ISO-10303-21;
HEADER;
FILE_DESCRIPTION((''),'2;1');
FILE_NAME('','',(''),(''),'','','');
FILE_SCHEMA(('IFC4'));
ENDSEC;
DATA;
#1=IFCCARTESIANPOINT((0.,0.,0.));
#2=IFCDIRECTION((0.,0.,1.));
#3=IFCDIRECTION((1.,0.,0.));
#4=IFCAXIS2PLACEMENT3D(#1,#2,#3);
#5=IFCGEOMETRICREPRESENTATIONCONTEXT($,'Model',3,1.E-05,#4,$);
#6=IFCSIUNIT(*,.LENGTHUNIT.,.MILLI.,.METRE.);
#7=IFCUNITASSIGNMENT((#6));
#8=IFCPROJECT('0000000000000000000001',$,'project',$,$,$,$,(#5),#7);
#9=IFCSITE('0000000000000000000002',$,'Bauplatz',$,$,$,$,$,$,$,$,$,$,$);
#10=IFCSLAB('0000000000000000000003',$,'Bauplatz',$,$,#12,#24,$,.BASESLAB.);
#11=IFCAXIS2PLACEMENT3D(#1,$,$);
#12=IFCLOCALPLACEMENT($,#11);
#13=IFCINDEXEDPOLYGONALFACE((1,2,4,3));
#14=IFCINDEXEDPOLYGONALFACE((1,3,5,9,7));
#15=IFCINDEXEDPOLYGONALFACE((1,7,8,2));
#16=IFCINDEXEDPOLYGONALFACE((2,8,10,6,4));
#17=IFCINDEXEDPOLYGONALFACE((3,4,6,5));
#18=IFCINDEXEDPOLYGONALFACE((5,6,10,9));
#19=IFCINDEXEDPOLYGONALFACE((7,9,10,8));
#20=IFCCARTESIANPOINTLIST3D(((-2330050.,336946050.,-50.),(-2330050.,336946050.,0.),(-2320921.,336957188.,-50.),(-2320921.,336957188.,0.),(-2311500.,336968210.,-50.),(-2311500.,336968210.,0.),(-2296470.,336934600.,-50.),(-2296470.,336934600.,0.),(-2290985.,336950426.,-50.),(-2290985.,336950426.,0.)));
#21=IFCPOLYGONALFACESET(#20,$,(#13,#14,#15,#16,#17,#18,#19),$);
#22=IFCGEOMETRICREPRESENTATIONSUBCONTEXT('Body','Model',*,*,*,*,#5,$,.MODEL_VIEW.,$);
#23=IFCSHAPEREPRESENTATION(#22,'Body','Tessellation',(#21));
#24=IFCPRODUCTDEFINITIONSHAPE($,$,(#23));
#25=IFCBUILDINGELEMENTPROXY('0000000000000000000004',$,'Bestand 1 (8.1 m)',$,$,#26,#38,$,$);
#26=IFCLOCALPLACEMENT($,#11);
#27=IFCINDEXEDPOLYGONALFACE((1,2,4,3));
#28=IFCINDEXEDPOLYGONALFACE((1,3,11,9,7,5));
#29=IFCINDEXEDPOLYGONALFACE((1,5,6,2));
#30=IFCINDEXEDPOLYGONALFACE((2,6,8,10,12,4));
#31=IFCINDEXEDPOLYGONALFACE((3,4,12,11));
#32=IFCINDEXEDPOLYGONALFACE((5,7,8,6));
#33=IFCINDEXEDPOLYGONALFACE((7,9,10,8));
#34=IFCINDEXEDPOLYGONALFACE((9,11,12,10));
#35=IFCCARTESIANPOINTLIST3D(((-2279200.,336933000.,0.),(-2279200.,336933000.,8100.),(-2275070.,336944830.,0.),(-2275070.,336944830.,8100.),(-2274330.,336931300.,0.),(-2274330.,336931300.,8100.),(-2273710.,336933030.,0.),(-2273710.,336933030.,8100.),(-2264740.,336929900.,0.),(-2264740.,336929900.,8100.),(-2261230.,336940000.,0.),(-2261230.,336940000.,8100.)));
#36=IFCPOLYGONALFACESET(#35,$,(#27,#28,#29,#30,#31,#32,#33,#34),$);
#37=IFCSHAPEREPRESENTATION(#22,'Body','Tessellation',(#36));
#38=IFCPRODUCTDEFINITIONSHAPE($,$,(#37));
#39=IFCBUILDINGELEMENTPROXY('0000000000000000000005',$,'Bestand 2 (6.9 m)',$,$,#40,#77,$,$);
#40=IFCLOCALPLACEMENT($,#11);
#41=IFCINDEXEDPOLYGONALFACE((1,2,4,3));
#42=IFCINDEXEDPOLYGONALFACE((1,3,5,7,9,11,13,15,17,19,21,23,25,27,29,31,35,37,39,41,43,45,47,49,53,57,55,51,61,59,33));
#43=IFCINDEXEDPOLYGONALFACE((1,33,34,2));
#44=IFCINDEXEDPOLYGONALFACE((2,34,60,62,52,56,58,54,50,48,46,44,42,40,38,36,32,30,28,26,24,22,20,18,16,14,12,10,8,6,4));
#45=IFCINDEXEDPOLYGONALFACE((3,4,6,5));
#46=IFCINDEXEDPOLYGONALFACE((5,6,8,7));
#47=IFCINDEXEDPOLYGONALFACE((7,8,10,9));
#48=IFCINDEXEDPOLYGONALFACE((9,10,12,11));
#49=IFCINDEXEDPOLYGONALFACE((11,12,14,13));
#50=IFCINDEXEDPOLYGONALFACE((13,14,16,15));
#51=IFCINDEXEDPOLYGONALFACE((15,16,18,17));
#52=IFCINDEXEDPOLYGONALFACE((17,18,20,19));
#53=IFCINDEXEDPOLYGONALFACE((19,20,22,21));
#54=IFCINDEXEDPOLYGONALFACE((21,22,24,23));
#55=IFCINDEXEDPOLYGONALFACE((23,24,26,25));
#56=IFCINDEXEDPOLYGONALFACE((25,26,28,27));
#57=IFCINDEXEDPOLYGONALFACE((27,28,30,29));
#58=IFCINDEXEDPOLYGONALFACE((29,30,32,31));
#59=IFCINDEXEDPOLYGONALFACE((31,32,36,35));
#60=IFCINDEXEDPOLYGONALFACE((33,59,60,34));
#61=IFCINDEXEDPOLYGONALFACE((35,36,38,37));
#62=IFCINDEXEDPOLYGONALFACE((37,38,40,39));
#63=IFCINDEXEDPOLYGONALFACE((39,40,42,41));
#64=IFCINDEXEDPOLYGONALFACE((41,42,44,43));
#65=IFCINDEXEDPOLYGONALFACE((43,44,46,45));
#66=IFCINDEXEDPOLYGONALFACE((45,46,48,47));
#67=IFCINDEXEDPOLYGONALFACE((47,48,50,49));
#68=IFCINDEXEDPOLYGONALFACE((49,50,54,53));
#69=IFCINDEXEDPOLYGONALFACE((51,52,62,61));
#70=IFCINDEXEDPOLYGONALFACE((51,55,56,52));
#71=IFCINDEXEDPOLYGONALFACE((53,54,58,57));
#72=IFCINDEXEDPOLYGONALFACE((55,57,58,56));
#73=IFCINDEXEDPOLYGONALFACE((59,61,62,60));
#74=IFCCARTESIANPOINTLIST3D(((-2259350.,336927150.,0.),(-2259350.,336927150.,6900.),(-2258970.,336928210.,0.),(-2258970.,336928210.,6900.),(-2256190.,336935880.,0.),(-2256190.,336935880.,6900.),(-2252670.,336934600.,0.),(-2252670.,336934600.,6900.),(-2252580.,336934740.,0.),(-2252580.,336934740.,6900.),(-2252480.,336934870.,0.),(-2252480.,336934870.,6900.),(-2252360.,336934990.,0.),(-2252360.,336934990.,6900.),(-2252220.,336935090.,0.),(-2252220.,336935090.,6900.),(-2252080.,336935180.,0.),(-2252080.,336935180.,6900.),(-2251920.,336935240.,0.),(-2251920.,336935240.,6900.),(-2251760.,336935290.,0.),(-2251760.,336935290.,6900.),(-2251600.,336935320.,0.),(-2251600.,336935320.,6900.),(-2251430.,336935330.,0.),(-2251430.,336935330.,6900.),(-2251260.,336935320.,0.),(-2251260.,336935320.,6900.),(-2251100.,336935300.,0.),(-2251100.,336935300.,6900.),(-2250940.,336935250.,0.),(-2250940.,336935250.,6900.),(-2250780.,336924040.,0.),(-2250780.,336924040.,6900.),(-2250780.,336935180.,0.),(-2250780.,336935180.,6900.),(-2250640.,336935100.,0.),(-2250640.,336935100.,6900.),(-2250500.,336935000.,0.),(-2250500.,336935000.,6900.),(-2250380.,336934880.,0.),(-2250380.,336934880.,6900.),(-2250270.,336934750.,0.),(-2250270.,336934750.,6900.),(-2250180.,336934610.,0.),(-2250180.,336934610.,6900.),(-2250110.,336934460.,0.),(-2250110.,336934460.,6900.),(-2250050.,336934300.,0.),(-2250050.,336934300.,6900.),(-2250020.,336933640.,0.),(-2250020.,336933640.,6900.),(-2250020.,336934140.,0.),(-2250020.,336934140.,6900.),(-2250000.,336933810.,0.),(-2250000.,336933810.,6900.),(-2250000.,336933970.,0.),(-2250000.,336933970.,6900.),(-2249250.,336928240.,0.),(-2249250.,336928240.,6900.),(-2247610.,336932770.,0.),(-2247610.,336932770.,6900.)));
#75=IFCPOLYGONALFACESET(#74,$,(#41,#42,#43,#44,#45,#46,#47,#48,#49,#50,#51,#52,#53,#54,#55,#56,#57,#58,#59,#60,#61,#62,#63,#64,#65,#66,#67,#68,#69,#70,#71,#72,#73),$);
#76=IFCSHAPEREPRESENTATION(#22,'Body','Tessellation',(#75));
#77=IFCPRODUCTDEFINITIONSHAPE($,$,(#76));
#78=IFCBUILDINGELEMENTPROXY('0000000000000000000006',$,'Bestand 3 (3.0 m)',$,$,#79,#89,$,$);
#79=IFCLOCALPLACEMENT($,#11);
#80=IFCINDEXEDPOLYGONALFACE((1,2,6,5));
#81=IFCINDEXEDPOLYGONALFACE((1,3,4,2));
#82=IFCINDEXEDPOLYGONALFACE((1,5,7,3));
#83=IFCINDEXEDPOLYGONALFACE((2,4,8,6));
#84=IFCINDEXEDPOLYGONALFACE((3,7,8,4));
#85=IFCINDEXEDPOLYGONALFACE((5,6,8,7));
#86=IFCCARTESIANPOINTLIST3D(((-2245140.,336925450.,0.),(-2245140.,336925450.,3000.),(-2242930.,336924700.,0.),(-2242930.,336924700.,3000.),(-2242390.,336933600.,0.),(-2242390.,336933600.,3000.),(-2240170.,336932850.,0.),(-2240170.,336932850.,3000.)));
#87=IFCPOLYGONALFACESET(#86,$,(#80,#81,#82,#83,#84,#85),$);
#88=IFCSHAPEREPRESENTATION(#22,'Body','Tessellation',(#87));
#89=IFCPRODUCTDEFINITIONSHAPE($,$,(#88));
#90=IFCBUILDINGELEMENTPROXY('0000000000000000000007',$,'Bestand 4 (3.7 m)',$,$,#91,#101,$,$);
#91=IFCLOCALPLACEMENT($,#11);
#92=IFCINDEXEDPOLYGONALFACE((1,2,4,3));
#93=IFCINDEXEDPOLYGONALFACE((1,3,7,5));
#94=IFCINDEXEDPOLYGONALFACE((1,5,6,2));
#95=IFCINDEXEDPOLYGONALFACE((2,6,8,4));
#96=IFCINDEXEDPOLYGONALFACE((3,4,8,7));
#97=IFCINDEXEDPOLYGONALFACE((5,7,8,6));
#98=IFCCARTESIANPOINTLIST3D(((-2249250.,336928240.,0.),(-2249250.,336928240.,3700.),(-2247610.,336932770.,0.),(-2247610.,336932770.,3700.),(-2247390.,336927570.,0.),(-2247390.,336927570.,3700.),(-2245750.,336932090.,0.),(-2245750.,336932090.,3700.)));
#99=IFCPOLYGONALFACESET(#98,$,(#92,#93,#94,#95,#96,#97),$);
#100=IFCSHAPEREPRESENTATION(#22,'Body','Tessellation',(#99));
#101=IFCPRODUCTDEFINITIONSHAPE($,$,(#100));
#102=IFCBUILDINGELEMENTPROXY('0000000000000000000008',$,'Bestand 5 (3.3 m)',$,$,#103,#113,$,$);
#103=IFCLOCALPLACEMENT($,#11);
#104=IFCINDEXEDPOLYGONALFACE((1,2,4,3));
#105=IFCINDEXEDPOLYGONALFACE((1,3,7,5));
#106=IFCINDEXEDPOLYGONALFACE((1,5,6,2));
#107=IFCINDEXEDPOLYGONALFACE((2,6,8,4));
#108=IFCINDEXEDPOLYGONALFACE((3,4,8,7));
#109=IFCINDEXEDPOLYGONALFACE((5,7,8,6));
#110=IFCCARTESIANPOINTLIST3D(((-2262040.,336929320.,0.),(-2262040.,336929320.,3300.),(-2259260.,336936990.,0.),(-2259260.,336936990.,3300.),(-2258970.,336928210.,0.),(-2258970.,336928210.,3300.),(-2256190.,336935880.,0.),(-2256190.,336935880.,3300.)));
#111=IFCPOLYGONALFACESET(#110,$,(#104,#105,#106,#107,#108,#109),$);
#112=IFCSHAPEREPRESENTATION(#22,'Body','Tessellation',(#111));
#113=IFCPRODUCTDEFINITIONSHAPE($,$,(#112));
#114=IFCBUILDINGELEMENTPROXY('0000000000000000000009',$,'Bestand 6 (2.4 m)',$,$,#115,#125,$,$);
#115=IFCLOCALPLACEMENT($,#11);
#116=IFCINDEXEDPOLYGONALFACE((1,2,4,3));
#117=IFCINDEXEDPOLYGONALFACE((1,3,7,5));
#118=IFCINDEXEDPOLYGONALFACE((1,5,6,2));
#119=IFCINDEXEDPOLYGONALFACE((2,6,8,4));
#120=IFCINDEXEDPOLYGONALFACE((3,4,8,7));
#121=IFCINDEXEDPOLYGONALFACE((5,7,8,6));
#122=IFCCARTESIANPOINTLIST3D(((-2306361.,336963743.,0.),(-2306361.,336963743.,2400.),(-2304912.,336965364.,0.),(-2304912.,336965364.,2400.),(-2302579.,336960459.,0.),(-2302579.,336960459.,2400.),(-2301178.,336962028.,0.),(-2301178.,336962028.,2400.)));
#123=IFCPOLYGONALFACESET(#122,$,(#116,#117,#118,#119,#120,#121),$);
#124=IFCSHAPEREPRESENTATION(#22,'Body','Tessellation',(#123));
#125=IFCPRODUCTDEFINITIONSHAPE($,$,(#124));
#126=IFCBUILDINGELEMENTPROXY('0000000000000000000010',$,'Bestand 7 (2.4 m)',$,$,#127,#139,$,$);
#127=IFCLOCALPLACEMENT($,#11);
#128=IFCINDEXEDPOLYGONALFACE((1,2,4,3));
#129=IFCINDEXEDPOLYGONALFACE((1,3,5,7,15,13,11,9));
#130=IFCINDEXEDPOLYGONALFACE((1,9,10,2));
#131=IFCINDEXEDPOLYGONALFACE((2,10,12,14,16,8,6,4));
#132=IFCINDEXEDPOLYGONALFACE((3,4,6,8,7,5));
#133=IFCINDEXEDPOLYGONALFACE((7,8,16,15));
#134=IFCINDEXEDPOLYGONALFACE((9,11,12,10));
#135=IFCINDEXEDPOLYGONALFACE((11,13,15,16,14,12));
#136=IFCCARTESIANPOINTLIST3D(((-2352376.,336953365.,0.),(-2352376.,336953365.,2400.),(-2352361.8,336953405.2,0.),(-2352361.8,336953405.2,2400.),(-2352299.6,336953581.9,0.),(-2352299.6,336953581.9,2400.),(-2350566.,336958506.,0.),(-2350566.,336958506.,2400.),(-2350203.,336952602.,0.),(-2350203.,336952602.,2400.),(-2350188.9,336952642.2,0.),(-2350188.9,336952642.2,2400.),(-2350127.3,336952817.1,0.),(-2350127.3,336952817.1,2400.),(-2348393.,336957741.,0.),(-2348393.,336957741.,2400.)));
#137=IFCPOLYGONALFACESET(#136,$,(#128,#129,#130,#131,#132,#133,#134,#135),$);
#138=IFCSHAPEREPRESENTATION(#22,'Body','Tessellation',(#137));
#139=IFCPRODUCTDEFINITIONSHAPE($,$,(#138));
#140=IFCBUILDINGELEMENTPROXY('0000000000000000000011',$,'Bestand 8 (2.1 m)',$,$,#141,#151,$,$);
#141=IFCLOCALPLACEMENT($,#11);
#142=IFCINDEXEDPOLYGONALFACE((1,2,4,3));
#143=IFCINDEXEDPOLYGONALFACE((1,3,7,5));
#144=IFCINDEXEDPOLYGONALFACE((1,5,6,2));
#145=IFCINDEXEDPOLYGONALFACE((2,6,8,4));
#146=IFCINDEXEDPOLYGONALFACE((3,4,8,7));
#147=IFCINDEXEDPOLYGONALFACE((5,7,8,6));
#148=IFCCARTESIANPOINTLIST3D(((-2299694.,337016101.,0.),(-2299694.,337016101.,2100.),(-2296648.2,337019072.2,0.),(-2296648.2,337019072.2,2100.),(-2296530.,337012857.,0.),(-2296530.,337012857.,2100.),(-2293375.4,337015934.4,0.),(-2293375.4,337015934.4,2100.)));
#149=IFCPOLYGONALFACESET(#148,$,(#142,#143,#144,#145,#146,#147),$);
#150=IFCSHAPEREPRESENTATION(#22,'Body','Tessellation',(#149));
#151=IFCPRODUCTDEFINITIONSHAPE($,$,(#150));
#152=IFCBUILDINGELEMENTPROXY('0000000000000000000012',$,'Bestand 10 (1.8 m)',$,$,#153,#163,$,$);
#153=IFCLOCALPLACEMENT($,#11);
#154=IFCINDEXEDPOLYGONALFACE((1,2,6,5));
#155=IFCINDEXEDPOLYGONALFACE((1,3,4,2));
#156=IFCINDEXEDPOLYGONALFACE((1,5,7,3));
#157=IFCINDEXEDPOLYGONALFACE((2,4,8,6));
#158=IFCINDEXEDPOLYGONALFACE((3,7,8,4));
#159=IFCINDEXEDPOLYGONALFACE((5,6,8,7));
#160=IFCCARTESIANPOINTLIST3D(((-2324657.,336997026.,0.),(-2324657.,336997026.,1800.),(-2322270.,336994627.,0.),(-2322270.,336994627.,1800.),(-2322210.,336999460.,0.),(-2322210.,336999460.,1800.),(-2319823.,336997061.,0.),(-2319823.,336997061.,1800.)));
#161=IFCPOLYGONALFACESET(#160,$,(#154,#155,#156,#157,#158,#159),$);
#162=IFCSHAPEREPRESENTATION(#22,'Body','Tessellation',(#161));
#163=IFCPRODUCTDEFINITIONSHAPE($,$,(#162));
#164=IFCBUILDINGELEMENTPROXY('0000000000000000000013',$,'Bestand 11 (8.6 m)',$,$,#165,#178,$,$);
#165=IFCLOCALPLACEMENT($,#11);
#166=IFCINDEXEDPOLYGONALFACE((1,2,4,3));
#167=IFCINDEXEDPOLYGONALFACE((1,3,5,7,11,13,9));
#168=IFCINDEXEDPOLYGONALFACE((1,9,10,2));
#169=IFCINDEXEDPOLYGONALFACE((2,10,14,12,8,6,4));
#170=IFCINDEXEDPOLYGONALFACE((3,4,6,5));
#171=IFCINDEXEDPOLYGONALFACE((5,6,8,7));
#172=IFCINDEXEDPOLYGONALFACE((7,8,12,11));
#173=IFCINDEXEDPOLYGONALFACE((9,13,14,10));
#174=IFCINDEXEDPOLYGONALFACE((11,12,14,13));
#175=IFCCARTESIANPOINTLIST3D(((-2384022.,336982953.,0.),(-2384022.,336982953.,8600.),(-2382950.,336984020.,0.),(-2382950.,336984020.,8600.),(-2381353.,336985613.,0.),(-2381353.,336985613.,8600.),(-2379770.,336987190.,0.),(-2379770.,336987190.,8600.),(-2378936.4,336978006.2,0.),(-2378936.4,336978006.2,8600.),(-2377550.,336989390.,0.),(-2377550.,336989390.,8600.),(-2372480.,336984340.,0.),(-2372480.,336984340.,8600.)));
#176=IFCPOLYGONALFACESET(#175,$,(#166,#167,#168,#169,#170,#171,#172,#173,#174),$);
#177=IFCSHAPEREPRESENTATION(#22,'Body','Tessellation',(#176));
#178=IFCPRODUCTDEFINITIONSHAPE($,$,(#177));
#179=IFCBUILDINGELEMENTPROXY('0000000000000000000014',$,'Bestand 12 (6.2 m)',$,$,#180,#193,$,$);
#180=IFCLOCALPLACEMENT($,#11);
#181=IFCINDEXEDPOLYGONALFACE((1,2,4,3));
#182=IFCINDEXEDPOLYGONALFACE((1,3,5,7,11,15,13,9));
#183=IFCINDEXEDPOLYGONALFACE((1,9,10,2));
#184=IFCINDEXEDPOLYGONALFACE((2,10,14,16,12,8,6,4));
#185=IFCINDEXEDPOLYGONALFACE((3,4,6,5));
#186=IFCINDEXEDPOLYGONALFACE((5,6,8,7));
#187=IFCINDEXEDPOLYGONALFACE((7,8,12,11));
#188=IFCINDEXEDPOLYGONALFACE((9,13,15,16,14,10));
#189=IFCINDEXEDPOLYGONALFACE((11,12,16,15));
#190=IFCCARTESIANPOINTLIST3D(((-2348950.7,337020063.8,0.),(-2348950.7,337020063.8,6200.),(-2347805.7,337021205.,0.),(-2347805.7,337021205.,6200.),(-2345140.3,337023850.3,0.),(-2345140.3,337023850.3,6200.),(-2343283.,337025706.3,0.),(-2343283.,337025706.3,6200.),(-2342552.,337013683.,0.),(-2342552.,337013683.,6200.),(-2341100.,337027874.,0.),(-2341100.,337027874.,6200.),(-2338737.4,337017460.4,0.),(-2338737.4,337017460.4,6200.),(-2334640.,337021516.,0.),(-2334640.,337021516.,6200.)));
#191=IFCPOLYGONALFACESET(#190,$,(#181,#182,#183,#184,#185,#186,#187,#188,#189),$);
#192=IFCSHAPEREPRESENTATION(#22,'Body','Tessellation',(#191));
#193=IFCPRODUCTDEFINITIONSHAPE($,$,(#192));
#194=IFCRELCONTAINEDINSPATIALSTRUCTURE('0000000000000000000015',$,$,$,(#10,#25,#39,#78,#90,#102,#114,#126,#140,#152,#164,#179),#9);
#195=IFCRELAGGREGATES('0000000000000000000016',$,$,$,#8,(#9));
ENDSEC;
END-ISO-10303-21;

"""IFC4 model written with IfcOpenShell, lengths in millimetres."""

from ifc_helpers import new_model, si_unit, frame, origin_with_axes, place, context, subcontext, project, spatial, indexed_curve, outline, extrude, element, save


model = new_model("IFC4")

# Units and contexts
model_context = context("Model", 3, precision=1e-05, world=origin_with_axes())
body_context = subcontext(model_context, "Body", "Model", "MODEL_VIEW")
ifc_project = project(units=[si_unit("LENGTHUNIT", "METRE", prefix="MILLI")], contexts=[model_context])

# Site
site = spatial("IfcSite", under=ifc_project, Name="Bauplatz")

# Slab
slab_placement = place(None, frame((0.0, 0.0, -50.0), z_axis=(0.0, 0.0, 1.0), x_axis=(1.0, 0.0, 0.0)))
element("IfcSlab", 1, at=slab_placement, inside=site, Name="Bauplatz", PredefinedType="BASESLAB", context=body_context, shape_type="SweptSolid", body=[
    extrude(outline(indexed_curve([(-2330050.0, 336946050.0), (-2296470.0, 336934600.0), (-2290985.0, 336950426.0), (-2311500.0, 336968210.0), (-2320921.0, 336957188.0)])), None, (0.0, 0.0, 1.0), 50.0),
])

# Building element proxies
proxy_1_placement = place(None, origin_with_axes())
element("IfcBuildingElementProxy", 2, at=proxy_1_placement, inside=site, Name="Bestand 1 (8.1 m)", context=body_context, shape_type="SweptSolid", body=[
    extrude(outline(indexed_curve([(-2261230.0, 336940000.0), (-2275070.0, 336944830.0), (-2279200.0, 336933000.0), (-2274330.0, 336931300.0), (-2273710.0, 336933030.0), (-2264740.0, 336929900.0)])), None, (0.0, 0.0, 1.0), 8100.0),
])
proxy_2_placement = place(None, origin_with_axes())
element("IfcBuildingElementProxy", 3, at=proxy_2_placement, inside=site, Name="Bestand 2 (6.9 m)", context=body_context, shape_type="SweptSolid", body=[
    extrude(outline(indexed_curve([(-2252670.0, 336934600.0), (-2256190.0, 336935880.0), (-2258970.0, 336928210.0), (-2259350.0, 336927150.0), (-2250780.0, 336924040.0), (-2249250.0, 336928240.0), (-2247610.0, 336932770.0), (-2250020.0, 336933640.0), (-2250000.0, 336933810.0), (-2250000.0, 336933970.0), (-2250020.0, 336934140.0), (-2250050.0, 336934300.0), (-2250110.0, 336934460.0), (-2250180.0, 336934610.0), (-2250270.0, 336934750.0), (-2250380.0, 336934880.0), (-2250500.0, 336935000.0), (-2250640.0, 336935100.0), (-2250780.0, 336935180.0), (-2250940.0, 336935250.0), (-2251100.0, 336935300.0), (-2251260.0, 336935320.0), (-2251430.0, 336935330.0), (-2251600.0, 336935320.0), (-2251760.0, 336935290.0), (-2251920.0, 336935240.0), (-2252080.0, 336935180.0), (-2252220.0, 336935090.0), (-2252360.0, 336934990.0), (-2252480.0, 336934870.0), (-2252580.0, 336934740.0)])), None, (0.0, 0.0, 1.0), 6900.0),
])
proxy_3_placement = place(None, origin_with_axes())
element("IfcBuildingElementProxy", 4, at=proxy_3_placement, inside=site, Name="Bestand 3 (3.0 m)", context=body_context, shape_type="SweptSolid", body=[
    extrude(outline(indexed_curve([(-2240170.0, 336932850.0), (-2242390.0, 336933600.0), (-2245140.0, 336925450.0), (-2242930.0, 336924700.0)])), None, (0.0, 0.0, 1.0), 3000.0),
])
proxy_4_placement = place(None, origin_with_axes())
element("IfcBuildingElementProxy", 5, at=proxy_4_placement, inside=site, Name="Bestand 4 (3.7 m)", context=body_context, shape_type="SweptSolid", body=[
    extrude(outline(indexed_curve([(-2245750.0, 336932090.0), (-2247610.0, 336932770.0), (-2249250.0, 336928240.0), (-2247390.0, 336927570.0)])), None, (0.0, 0.0, 1.0), 3700.0),
])
proxy_5_placement = place(None, origin_with_axes())
element("IfcBuildingElementProxy", 6, at=proxy_5_placement, inside=site, Name="Bestand 5 (3.3 m)", context=body_context, shape_type="SweptSolid", body=[
    extrude(outline(indexed_curve([(-2256190.0, 336935880.0), (-2259260.0, 336936990.0), (-2262040.0, 336929320.0), (-2258970.0, 336928210.0)])), None, (0.0, 0.0, 1.0), 3300.0),
])
proxy_6_placement = place(None, origin_with_axes())
element("IfcBuildingElementProxy", 7, at=proxy_6_placement, inside=site, Name="Bestand 6 (2.4 m)", context=body_context, shape_type="SweptSolid", body=[
    extrude(outline(indexed_curve([(-2301178.0, 336962028.0), (-2304912.0, 336965364.0), (-2306361.0, 336963743.0), (-2302579.0, 336960459.0)])), None, (0.0, 0.0, 1.0), 2400.0),
])
proxy_7_placement = place(None, origin_with_axes())
element("IfcBuildingElementProxy", 8, at=proxy_7_placement, inside=site, Name="Bestand 7 (2.4 m)", context=body_context, shape_type="SweptSolid", body=[
    extrude(outline(indexed_curve([(-2348393.0, 336957741.0), (-2350566.0, 336958506.0), (-2352299.6, 336953581.9), (-2352361.8, 336953405.2), (-2352376.0, 336953365.0), (-2350203.0, 336952602.0), (-2350188.9, 336952642.2), (-2350127.3, 336952817.1)])), None, (0.0, 0.0, 1.0), 2400.0),
])
proxy_8_placement = place(None, origin_with_axes())
element("IfcBuildingElementProxy", 9, at=proxy_8_placement, inside=site, Name="Bestand 8 (2.1 m)", context=body_context, shape_type="SweptSolid", body=[
    extrude(outline(indexed_curve([(-2293375.4, 337015934.4), (-2296648.2, 337019072.2), (-2299694.0, 337016101.0), (-2296530.0, 337012857.0)])), None, (0.0, 0.0, 1.0), 2100.0),
])
proxy_9_placement = place(None, origin_with_axes())
element("IfcBuildingElementProxy", 10, at=proxy_9_placement, inside=site, Name="Bestand 10 (1.8 m)", context=body_context, shape_type="SweptSolid", body=[
    extrude(outline(indexed_curve([(-2319823.0, 336997061.0), (-2322210.0, 336999460.0), (-2324657.0, 336997026.0), (-2322270.0, 336994627.0)])), None, (0.0, 0.0, 1.0), 1800.0),
])
proxy_10_placement = place(None, origin_with_axes())
element("IfcBuildingElementProxy", 11, at=proxy_10_placement, inside=site, Name="Bestand 11 (8.6 m)", context=body_context, shape_type="SweptSolid", body=[
    extrude(outline(indexed_curve([(-2372480.0, 336984340.0), (-2377550.0, 336989390.0), (-2379770.0, 336987190.0), (-2381353.0, 336985613.0), (-2382950.0, 336984020.0), (-2384022.0, 336982953.0), (-2378936.4, 336978006.2)])), None, (0.0, 0.0, 1.0), 8600.0),
])
proxy_11_placement = place(None, origin_with_axes())
element("IfcBuildingElementProxy", 12, at=proxy_11_placement, inside=site, Name="Bestand 12 (6.2 m)", context=body_context, shape_type="SweptSolid", body=[
    extrude(outline(indexed_curve([(-2334640.0, 337021516.0), (-2341100.0, 337027874.0), (-2343283.0, 337025706.3), (-2345140.3, 337023850.3), (-2347805.7, 337021205.0), (-2348950.7, 337020063.8), (-2342552.0, 337013683.0), (-2338737.4, 337017460.4)])), None, (0.0, 0.0, 1.0), 6200.0),
])

save(model, "model.ifc")
